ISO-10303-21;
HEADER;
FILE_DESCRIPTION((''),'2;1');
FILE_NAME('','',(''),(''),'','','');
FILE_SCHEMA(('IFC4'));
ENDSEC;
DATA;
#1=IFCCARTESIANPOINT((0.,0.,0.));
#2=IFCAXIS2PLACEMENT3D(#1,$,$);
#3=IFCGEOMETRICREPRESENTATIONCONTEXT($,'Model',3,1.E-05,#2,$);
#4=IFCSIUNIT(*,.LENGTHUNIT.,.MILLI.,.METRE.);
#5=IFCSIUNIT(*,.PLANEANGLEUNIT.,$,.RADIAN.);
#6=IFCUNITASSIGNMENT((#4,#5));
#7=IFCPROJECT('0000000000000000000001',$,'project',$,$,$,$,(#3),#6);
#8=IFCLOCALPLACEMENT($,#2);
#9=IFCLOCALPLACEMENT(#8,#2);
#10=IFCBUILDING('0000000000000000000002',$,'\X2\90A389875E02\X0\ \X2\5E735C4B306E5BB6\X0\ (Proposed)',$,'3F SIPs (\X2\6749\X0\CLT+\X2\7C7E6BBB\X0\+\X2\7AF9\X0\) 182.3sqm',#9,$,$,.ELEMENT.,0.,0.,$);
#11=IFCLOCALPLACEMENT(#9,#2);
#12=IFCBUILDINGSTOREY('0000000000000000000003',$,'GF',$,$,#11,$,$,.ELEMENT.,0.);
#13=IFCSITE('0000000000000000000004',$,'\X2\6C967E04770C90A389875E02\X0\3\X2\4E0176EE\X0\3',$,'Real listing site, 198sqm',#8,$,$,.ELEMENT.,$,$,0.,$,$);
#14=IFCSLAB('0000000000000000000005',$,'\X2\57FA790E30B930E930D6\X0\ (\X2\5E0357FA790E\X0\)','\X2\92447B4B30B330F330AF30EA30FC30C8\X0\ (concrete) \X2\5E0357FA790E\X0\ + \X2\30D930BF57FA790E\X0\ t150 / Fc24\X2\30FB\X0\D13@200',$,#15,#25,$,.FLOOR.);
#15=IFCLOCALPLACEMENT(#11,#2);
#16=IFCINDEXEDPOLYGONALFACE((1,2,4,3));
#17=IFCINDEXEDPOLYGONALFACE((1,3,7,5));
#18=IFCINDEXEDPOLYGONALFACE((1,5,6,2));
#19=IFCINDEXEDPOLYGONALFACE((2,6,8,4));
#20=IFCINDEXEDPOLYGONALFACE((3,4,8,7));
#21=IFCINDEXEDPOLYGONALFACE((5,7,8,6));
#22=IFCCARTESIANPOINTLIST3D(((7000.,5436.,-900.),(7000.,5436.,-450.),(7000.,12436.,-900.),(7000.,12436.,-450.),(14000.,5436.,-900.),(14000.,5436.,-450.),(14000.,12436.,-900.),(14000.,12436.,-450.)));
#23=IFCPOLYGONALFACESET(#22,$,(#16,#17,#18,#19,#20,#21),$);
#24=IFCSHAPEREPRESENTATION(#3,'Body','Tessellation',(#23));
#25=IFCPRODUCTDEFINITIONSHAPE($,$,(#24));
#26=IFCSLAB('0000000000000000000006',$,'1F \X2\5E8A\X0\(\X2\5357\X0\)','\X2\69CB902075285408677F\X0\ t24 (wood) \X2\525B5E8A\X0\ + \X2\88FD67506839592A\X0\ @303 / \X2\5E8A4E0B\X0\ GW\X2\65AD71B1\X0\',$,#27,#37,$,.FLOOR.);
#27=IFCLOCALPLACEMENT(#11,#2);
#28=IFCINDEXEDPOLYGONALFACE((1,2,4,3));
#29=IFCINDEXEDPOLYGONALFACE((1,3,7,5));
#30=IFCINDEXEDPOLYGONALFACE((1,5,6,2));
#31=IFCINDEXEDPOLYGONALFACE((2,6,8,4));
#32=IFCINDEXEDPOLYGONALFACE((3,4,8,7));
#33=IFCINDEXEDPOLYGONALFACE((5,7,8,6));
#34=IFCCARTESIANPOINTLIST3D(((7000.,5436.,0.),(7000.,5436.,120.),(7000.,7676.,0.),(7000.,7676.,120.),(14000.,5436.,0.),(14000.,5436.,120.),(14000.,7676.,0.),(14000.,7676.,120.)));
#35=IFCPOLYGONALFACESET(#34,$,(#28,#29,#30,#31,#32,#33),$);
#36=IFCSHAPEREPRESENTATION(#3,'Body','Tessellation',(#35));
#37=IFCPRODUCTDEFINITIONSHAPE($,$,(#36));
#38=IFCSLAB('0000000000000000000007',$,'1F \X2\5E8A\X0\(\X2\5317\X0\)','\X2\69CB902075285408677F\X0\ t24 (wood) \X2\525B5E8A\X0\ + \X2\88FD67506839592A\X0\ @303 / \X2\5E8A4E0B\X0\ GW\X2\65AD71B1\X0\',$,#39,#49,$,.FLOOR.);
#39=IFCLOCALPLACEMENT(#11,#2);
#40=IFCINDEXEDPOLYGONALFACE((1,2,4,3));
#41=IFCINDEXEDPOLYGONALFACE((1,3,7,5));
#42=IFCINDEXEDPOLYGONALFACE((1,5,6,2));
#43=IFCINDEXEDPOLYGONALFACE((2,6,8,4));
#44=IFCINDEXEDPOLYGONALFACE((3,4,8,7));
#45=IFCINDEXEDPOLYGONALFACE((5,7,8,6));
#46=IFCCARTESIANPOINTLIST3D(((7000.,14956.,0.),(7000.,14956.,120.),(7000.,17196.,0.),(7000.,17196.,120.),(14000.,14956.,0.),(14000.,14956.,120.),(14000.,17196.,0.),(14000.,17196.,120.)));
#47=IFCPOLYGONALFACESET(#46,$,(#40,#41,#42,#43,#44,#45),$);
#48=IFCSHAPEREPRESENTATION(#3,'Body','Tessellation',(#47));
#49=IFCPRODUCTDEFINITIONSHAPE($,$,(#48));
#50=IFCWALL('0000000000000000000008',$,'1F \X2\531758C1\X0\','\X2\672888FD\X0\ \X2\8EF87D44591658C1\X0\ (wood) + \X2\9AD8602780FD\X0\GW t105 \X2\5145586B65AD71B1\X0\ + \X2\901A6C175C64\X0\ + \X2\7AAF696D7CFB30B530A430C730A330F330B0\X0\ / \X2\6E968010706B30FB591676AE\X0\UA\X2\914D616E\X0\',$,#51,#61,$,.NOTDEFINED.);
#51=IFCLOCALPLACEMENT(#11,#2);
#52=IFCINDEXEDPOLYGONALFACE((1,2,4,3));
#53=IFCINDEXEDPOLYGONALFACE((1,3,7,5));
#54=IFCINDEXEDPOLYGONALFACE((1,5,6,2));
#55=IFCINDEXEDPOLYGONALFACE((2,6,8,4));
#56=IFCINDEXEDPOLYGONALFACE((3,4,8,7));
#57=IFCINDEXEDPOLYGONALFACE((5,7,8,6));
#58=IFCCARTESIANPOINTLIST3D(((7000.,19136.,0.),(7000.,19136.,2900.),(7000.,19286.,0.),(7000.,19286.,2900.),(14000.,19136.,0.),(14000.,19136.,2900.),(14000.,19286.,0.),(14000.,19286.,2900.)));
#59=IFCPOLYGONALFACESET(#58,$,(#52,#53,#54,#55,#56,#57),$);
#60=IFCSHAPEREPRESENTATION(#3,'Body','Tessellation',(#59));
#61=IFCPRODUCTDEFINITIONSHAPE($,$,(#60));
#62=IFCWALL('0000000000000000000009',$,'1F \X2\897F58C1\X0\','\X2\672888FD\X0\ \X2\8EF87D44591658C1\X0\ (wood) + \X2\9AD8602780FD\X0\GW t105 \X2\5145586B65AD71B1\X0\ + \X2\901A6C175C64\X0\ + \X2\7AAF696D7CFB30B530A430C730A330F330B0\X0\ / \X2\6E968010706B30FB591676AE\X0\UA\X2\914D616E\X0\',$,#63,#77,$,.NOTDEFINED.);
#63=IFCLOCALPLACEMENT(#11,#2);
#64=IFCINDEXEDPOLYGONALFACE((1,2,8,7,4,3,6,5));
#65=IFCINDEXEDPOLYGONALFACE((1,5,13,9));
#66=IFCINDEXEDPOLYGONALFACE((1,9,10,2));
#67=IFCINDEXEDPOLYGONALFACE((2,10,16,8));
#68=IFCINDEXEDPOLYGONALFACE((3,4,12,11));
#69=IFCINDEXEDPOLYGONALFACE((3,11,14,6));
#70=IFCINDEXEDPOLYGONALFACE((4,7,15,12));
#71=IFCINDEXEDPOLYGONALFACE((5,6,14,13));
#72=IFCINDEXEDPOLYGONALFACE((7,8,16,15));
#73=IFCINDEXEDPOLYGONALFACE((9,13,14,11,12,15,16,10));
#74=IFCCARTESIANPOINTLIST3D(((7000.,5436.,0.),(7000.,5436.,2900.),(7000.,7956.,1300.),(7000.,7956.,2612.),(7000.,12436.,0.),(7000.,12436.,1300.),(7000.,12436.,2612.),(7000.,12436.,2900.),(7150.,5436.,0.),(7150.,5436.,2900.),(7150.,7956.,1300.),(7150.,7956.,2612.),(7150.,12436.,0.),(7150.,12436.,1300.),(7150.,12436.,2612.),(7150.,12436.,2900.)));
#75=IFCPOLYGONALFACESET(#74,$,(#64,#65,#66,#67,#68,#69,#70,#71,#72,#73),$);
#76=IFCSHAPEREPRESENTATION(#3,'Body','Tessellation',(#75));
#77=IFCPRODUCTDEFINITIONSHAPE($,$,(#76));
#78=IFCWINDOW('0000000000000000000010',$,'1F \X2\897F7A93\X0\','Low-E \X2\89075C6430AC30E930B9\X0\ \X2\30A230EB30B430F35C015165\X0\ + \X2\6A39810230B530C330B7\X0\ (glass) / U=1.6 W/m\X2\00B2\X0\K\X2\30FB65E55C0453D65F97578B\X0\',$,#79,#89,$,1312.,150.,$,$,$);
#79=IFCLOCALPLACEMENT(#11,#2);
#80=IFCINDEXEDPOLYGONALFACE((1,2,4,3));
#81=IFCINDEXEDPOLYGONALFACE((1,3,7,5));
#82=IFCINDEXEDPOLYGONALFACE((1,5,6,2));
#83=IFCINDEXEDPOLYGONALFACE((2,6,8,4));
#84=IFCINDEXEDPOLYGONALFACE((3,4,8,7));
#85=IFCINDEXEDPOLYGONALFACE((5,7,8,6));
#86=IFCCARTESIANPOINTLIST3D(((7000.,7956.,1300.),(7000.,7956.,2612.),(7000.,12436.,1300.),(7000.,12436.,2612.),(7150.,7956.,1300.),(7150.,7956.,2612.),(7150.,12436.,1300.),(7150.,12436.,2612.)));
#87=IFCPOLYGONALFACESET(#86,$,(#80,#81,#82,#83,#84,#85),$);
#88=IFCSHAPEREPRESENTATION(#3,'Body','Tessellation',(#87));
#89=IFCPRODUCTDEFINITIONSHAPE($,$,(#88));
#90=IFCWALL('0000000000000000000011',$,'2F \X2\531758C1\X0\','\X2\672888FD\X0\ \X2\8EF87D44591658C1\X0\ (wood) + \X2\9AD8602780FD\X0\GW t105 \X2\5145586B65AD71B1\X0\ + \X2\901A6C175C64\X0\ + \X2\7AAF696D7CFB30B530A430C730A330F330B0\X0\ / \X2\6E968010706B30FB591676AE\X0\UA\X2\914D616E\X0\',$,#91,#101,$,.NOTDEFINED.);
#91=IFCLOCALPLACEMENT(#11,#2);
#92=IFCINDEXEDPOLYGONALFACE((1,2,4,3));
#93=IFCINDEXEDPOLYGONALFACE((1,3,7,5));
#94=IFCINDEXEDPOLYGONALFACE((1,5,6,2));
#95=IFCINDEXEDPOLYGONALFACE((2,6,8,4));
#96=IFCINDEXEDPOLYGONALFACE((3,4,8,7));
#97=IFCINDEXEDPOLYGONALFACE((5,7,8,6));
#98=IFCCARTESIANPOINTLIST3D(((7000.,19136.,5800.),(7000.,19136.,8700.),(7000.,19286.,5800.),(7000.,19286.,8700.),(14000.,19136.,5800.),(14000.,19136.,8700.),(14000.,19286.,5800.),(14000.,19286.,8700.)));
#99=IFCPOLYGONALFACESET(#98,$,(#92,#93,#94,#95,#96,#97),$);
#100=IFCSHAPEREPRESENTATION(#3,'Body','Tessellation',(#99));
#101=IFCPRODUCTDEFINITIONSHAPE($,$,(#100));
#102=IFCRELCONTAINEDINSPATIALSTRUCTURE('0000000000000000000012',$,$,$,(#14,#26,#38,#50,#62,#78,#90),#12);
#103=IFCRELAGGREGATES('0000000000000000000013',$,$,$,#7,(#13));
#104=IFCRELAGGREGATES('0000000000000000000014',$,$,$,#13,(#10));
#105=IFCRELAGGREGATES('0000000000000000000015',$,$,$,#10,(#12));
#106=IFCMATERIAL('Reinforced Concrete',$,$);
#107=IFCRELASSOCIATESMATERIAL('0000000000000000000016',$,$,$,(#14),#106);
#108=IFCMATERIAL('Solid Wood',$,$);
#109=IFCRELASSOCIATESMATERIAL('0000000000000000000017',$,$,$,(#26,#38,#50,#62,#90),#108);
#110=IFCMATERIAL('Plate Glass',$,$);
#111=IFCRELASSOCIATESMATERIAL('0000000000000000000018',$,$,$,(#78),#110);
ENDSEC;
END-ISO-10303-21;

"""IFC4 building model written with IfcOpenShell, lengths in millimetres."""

from ifc_helpers import new_model, si_unit, frame, frame_2d, origin, place, context, project, spatial, rectangle, extrude, material, element, fill, save


model = new_model("IFC4")

# Units and contexts
model_context = context("Model", 3, precision=1e-05, world=origin())
ifc_project = project(units=[si_unit("LENGTHUNIT", "METRE", prefix="MILLI"), si_unit("PLANEANGLEUNIT", "RADIAN")], contexts=[model_context])

# Site, building, storey
site_placement = place(None, origin())
site = spatial("IfcSite", under=ifc_project, at=site_placement, Name="沖縄県那覇市3丁目3", ObjectType="Real listing site, 198sqm", CompositionType="ELEMENT", RefElevation=0.0)
building_placement = place(site_placement, origin())
building = spatial("IfcBuilding", under=site, at=building_placement, Name="那覇市 平屋の家 (Proposed)", ObjectType="3F SIPs (杉CLT+籾殻+竹) 182.3sqm", CompositionType="ELEMENT", ElevationOfRefHeight=0.0, ElevationOfTerrain=0.0)
storey_placement = place(building_placement, origin())
storey = spatial("IfcBuildingStorey", under=building, at=storey_placement, Name="GF", CompositionType="ELEMENT", Elevation=0.0)

# Slabs
ifc_material_1 = material(Name="Reinforced Concrete")
slab_1_placement = place(storey_placement, frame((3500.0, 2718.0, -450.0)))
element("IfcSlab", 1, at=slab_1_placement, inside=storey, material=ifc_material_1, Name="基礎スラブ (布基礎)", Description="鉄筋コンクリート (concrete) 布基礎 + ベタ基礎 t150 / Fc24・D13@200", PredefinedType="FLOOR", context=model_context, shape_type="SweptSolid", body=[
    extrude(rectangle(XDim=7000.0, YDim=7000.0, at=frame_2d((3500.0, 3500.0))), frame((3500.0, 2718.0, -450.0)), (0.0, 0.0, 1.0), 450.0),
])
ifc_material_2 = material(Name="Solid Wood")
slab_2_placement = place(storey_placement, frame((3500.0, 2718.0, 0.0)))
element("IfcSlab", 2, at=slab_2_placement, inside=storey, material=ifc_material_2, Name="1F 床(南)", Description="構造用合板 t24 (wood) 剛床 + 製材根太 @303 / 床下 GW断熱", PredefinedType="FLOOR", context=model_context, shape_type="SweptSolid", body=[
    extrude(rectangle(XDim=7000.0, YDim=2240.0, at=frame_2d((3500.0, 1120.0))), frame((3500.0, 2718.0, 0.0)), (0.0, 0.0, 1.0), 120.0),
])
slab_3_placement = place(storey_placement, frame((3500.0, 7478.0, 0.0)))
element("IfcSlab", 3, at=slab_3_placement, inside=storey, material=ifc_material_2, Name="1F 床(北)", Description="構造用合板 t24 (wood) 剛床 + 製材根太 @303 / 床下 GW断熱", PredefinedType="FLOOR", context=model_context, shape_type="SweptSolid", body=[
    extrude(rectangle(XDim=7000.0, YDim=2240.0, at=frame_2d((3500.0, 1120.0))), frame((3500.0, 7478.0, 0.0)), (0.0, 0.0, 1.0), 120.0),
])

# Shared definitions
ifc_material_3 = material(Name="Plate Glass")

# Wall
wall_1_placement = place(storey_placement, frame((3500.0, 9568.0, 0.0)))
element("IfcWall", 4, at=wall_1_placement, inside=storey, material=ifc_material_2, Name="1F 北壁", Description="木製 軸組外壁 (wood) + 高性能GW t105 充填断熱 + 通気層 + 窯業系サイディング / 準耐火・外皮UA配慮", PredefinedType="NOTDEFINED", context=model_context, shape_type="SweptSolid", body=[
    extrude(rectangle(XDim=7000.0, YDim=150.0, at=frame_2d((3500.0, 75.0))), frame((3500.0, 9568.0, 0.0)), (0.0, 0.0, 1.0), 2900.0),
])

# Wall, opening, window
wall_2_placement = place(storey_placement, frame((3500.0, 2718.0, 0.0)))
wall_2 = element("IfcWall", 5, at=wall_2_placement, inside=storey, material=ifc_material_2, Name="1F 西壁", Description="木製 軸組外壁 (wood) + 高性能GW t105 充填断熱 + 通気層 + 窯業系サイディング / 準耐火・外皮UA配慮", PredefinedType="NOTDEFINED", context=model_context, shape_type="SweptSolid", body=[
    extrude(rectangle(XDim=150.0, YDim=7000.0, at=frame_2d((75.0, 3500.0))), frame((3500.0, 2718.0, 0.0)), (0.0, 0.0, 1.0), 2900.0),
])
opening_1_placement = place(storey_placement, frame((3500.0, 3978.0, 650.0)))
opening_1 = element("IfcOpeningElement", 6, at=opening_1_placement, cuts=wall_2, PredefinedType="NOTDEFINED", context=model_context, shape_type="SweptSolid", body=[
    extrude(rectangle(XDim=150.0, YDim=4480.0, at=frame_2d((75.0, 2240.0))), frame((3500.0, 3978.0, 650.0)), (0.0, 0.0, 1.0), 1312.0),
])
window_1_placement = place(storey_placement, frame((3500.0, 3978.0, 650.0)))
window_1 = element("IfcWindow", 7, at=window_1_placement, inside=storey, material=ifc_material_3, Name="1F 西窓", Description="Low-E 複層ガラス アルゴン封入 + 樹脂サッシ (glass) / U=1.6 W/m²K・日射取得型", OverallHeight=1312.0, OverallWidth=150.0, context=model_context, shape_type="SweptSolid", body=[
    extrude(rectangle(XDim=150.0, YDim=4480.0, at=frame_2d((75.0, 2240.0))), frame((3500.0, 3978.0, 650.0)), (0.0, 0.0, 1.0), 1312.0),
])
fill(opening_1, window_1)

# Wall
wall_3_placement = place(storey_placement, frame((3500.0, 9568.0, 2900.0)))
element("IfcWall", 8, at=wall_3_placement, inside=storey, material=ifc_material_2, Name="2F 北壁", Description="木製 軸組外壁 (wood) + 高性能GW t105 充填断熱 + 通気層 + 窯業系サイディング / 準耐火・外皮UA配慮", PredefinedType="NOTDEFINED", context=model_context, shape_type="SweptSolid", body=[
    extrude(rectangle(XDim=7000.0, YDim=150.0, at=frame_2d((3500.0, 75.0))), frame((3500.0, 9568.0, 2900.0)), (0.0, 0.0, 1.0), 2900.0),
])

save(model, "model.ifc")
